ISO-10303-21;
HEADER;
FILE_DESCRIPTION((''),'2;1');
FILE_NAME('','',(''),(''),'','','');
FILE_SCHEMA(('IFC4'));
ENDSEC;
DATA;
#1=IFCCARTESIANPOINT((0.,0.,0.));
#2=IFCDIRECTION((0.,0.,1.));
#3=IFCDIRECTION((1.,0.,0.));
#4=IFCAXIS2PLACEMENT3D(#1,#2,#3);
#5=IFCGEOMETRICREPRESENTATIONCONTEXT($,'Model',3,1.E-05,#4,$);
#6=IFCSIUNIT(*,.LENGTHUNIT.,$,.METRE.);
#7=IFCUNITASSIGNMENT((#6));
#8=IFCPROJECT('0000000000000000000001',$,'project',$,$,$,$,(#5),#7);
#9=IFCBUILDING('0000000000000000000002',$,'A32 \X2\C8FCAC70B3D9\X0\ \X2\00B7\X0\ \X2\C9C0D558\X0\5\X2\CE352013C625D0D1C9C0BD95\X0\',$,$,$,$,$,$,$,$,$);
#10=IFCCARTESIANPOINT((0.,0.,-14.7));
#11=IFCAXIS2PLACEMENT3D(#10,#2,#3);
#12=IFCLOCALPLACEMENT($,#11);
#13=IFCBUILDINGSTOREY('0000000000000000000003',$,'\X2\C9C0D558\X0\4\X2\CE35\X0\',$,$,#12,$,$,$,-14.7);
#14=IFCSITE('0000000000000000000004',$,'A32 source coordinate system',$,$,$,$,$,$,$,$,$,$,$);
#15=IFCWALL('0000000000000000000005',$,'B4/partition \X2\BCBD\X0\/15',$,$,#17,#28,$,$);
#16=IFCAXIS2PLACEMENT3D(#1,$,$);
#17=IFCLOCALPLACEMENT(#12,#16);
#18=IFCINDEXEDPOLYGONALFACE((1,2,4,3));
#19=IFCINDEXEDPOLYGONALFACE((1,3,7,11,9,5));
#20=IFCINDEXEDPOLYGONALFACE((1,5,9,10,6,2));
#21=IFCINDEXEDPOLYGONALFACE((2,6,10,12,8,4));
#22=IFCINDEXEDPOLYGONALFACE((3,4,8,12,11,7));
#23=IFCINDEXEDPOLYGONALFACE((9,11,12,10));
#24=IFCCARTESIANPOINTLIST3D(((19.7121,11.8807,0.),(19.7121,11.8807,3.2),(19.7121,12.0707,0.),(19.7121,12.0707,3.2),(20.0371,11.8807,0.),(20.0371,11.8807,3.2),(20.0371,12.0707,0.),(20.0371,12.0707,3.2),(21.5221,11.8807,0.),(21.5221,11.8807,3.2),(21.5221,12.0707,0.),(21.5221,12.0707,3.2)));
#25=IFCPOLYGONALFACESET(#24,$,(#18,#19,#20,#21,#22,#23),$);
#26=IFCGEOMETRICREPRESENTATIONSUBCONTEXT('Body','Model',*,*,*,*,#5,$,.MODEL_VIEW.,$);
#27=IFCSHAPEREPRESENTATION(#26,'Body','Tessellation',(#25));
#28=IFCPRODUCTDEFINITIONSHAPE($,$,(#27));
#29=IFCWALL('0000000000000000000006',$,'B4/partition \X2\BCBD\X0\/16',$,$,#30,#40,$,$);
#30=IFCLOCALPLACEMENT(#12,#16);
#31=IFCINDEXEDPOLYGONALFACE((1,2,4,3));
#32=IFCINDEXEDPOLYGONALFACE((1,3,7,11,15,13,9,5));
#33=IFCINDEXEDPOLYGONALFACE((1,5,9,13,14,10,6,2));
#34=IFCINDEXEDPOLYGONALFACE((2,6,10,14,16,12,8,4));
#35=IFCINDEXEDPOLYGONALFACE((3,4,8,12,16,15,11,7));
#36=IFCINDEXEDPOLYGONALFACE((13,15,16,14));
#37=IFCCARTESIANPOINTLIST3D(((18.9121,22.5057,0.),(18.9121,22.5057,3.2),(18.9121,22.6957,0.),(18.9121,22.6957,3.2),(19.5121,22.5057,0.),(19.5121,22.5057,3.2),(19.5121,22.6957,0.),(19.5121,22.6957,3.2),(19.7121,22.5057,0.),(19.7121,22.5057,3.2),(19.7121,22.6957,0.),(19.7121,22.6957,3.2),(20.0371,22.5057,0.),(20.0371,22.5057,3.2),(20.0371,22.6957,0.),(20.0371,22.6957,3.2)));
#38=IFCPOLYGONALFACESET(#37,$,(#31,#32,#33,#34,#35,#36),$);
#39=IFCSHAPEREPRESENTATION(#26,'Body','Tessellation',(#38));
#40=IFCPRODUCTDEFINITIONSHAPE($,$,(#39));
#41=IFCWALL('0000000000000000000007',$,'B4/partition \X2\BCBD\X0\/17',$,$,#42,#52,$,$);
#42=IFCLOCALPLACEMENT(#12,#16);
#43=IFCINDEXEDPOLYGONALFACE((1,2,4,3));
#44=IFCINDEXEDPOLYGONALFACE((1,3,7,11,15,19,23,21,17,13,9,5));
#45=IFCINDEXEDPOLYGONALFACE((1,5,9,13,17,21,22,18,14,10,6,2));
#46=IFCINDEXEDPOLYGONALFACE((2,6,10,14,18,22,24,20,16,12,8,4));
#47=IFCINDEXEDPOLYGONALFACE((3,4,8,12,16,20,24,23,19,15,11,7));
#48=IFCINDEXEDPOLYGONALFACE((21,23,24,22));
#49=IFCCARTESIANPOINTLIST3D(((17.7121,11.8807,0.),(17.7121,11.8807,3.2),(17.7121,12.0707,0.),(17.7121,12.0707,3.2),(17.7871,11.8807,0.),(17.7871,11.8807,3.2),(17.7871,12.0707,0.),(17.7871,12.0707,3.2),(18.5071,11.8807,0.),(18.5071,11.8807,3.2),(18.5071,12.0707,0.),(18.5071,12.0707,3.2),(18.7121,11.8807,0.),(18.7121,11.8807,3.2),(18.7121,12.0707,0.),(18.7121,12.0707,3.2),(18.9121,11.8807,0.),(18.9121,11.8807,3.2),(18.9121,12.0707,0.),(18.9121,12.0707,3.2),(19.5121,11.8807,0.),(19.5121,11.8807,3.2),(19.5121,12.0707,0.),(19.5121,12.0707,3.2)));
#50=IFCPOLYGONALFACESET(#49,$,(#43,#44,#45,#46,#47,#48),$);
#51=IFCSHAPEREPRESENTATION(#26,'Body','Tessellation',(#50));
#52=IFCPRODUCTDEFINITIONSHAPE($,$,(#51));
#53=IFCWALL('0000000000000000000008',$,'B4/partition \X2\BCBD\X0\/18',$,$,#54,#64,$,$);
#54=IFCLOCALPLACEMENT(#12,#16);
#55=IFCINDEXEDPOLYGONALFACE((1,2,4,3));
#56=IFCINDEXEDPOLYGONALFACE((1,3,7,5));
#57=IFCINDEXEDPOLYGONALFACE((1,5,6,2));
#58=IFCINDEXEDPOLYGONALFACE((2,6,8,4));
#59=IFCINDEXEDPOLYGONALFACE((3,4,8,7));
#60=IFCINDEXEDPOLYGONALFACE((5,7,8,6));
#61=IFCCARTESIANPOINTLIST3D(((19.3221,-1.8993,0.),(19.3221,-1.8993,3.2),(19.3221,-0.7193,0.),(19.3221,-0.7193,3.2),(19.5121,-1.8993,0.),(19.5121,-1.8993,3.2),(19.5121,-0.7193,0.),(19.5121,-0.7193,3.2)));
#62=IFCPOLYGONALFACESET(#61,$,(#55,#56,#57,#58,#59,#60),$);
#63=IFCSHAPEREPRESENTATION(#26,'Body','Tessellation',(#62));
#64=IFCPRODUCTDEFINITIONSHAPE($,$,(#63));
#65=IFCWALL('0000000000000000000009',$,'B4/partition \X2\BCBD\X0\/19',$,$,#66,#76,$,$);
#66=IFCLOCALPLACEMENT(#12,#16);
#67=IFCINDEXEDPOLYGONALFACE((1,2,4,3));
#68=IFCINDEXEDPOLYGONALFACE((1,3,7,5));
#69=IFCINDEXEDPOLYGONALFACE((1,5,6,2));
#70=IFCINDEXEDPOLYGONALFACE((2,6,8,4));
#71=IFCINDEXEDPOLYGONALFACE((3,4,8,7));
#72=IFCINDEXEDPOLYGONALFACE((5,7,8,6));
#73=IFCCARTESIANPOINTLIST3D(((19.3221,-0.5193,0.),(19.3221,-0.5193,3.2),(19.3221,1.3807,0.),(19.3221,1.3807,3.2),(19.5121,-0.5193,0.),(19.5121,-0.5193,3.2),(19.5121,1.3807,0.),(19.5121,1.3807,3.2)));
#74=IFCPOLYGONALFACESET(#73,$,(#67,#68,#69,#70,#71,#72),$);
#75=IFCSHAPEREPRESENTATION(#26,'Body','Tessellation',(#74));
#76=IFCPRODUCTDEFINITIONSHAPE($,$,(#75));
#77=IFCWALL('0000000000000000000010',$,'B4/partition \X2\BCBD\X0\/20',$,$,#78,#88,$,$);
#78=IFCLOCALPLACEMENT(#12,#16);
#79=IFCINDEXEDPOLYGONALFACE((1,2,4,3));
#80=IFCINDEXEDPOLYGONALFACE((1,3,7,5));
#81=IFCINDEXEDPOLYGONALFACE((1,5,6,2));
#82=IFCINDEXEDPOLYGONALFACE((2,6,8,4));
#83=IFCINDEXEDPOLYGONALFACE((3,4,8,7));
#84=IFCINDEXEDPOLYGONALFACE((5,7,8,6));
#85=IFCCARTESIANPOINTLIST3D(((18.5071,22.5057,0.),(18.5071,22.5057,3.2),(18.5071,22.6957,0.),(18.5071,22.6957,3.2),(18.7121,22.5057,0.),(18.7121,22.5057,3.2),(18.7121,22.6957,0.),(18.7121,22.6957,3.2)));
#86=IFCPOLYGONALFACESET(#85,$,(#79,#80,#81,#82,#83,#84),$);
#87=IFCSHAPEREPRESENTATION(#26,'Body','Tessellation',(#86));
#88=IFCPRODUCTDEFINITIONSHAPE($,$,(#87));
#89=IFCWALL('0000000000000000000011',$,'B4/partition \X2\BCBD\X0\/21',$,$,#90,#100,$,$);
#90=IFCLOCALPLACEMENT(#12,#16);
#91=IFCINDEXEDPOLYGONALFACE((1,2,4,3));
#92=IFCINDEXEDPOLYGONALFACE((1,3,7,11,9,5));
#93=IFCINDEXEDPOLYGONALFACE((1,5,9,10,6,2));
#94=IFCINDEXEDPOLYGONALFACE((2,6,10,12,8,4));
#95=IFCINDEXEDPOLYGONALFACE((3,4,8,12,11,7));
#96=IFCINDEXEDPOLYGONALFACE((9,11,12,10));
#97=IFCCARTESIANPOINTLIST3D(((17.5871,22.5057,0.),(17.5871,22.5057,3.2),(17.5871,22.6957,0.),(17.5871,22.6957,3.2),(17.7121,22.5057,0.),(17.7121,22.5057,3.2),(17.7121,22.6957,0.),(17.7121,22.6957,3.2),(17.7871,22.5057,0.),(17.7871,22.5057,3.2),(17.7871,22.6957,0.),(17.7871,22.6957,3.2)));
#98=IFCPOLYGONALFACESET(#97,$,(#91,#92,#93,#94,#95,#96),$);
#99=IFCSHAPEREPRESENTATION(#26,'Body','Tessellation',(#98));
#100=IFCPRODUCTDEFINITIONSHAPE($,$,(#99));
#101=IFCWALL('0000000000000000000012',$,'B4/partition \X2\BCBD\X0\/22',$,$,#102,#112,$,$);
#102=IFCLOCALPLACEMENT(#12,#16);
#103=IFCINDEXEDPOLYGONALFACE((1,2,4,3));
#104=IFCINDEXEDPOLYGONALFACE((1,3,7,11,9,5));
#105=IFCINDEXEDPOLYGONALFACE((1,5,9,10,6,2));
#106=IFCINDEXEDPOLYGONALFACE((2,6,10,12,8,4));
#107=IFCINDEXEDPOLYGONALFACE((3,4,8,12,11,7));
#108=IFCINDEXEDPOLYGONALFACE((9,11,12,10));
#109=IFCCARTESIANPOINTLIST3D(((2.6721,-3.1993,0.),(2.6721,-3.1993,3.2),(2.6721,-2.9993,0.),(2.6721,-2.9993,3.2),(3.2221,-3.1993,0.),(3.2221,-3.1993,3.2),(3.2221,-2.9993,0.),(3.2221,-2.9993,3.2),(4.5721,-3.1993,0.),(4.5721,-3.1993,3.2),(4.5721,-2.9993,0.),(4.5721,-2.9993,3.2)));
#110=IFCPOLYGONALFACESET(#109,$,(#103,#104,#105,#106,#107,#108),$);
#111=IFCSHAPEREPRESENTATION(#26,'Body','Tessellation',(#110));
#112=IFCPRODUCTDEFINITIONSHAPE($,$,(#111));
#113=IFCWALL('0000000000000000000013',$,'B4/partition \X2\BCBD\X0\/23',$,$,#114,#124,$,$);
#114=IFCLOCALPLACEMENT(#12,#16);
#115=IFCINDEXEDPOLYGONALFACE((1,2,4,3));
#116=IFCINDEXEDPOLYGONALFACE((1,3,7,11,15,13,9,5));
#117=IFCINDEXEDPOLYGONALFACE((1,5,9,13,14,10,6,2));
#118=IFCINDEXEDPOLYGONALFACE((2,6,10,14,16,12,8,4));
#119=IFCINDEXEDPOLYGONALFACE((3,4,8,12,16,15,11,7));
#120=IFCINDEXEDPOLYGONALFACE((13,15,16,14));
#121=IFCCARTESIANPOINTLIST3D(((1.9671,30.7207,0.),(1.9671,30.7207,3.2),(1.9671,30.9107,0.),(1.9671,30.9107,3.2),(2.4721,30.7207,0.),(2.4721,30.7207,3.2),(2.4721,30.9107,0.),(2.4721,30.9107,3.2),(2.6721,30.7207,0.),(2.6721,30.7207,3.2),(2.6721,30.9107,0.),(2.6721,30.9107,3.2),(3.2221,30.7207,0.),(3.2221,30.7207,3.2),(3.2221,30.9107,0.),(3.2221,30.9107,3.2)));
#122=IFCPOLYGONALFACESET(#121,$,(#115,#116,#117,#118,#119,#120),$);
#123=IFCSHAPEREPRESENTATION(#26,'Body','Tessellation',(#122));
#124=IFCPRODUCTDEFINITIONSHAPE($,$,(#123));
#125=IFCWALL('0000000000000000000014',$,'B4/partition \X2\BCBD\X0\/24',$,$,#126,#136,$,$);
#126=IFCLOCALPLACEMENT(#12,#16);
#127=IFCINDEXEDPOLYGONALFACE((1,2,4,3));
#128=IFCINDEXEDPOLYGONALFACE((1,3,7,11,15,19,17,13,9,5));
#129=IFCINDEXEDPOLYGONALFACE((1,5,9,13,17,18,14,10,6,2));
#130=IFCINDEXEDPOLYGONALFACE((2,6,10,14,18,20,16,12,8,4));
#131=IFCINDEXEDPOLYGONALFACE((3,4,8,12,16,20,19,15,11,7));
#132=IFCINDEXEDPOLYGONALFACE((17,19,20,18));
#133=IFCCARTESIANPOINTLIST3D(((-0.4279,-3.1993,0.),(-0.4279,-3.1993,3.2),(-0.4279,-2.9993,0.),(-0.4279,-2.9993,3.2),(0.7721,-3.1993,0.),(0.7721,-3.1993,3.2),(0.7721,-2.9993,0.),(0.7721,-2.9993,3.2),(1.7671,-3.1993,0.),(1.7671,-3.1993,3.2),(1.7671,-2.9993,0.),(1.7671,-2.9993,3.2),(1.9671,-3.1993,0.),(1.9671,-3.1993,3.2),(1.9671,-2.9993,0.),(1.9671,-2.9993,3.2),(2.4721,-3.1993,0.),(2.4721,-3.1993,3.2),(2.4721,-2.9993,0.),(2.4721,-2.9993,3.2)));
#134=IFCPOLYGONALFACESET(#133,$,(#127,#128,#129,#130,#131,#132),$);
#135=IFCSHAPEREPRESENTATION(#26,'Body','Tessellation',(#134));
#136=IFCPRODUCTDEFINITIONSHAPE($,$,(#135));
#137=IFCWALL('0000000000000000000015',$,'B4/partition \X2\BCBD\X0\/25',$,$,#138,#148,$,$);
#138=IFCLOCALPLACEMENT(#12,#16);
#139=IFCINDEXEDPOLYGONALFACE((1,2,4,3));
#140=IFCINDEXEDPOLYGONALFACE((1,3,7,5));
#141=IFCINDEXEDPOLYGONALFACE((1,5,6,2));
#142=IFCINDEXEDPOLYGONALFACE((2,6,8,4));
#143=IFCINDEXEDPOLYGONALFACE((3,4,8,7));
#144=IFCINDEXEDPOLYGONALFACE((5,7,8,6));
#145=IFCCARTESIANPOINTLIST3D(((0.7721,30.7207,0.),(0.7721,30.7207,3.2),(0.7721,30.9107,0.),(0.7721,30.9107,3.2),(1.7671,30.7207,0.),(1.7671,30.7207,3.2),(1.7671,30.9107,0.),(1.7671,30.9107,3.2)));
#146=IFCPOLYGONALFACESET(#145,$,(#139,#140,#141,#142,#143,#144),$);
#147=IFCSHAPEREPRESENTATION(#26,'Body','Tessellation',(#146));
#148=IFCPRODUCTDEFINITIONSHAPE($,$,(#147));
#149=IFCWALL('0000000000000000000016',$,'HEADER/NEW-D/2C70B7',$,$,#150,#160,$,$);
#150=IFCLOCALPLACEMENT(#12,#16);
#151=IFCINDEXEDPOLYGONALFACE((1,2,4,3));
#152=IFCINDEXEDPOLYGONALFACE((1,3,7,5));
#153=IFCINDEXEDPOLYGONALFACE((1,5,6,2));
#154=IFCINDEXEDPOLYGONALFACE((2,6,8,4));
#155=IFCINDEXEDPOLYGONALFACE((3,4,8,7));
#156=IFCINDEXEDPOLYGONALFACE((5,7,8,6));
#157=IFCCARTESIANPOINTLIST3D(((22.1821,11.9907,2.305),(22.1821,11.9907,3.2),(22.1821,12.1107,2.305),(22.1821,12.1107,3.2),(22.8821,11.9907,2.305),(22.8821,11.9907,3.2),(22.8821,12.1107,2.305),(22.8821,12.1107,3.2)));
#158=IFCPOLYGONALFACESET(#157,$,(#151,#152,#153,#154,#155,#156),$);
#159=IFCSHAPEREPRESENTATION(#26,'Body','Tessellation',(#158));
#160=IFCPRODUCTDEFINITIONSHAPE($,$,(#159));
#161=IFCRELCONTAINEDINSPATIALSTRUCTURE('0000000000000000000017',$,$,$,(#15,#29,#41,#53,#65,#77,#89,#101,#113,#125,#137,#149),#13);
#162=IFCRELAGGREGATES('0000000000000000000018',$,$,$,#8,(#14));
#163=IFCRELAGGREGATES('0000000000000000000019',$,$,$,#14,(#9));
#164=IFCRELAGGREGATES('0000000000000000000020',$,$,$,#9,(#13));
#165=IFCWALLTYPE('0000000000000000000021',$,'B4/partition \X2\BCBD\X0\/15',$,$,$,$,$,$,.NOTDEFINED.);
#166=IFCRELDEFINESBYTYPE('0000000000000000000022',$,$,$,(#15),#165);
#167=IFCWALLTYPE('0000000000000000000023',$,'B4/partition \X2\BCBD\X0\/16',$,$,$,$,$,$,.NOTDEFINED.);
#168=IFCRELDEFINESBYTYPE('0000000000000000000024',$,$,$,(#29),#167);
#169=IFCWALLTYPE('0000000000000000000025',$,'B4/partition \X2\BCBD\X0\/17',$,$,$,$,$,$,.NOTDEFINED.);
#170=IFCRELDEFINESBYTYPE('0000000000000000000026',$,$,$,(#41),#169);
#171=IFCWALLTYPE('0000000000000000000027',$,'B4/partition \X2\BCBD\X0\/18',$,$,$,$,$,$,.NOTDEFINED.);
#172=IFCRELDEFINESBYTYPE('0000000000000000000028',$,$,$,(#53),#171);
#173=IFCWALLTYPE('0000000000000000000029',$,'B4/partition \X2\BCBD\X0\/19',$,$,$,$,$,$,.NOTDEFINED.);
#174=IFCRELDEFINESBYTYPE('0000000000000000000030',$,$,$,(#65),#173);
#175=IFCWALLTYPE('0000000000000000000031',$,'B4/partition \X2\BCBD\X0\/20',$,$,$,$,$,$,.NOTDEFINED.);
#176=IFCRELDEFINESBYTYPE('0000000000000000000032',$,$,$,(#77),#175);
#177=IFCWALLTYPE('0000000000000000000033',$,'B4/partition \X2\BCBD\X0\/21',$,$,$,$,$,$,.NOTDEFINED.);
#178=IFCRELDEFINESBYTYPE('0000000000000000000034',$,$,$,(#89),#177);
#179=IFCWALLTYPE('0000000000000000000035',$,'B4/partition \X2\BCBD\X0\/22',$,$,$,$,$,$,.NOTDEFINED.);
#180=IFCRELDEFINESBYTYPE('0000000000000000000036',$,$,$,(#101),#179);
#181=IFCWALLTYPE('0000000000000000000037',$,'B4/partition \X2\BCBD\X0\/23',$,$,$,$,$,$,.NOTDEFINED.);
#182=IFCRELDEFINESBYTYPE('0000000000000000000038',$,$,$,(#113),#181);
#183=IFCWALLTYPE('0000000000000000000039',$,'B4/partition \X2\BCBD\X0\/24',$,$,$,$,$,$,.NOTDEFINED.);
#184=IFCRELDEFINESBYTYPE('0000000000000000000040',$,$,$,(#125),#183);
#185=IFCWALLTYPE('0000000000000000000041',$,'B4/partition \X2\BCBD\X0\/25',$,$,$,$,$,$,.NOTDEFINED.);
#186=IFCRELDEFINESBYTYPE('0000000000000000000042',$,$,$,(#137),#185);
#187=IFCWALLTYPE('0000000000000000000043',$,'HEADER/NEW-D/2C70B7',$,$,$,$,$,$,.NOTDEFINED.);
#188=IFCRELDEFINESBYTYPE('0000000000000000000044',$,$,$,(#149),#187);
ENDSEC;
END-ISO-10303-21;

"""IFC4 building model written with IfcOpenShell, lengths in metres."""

from ifc_helpers import new_model, si_unit, frame, origin, origin_with_axes, place, context, subcontext, project, spatial, polyline, outline, extrude, source, transform, mapped, type_object, type_shapes, element, save


model = new_model("IFC4")

# Units and contexts
model_context = context("Model", 3, precision=1e-05, world=origin_with_axes())
body_context = subcontext(model_context, "Body", "Model", "MODEL_VIEW")
ifc_project = project(units=[si_unit("LENGTHUNIT", "METRE")], contexts=[model_context])

# Site, building, storey
site = spatial("IfcSite", under=ifc_project, Name="A32 source coordinate system")
building = spatial("IfcBuilding", under=site, Name="A32 주거동 · 지하5층–옥탑지붕")
storey_placement = place(None, frame((0.0, 0.0, -14.7), z_axis=(0.0, 0.0, 1.0), x_axis=(1.0, 0.0, 0.0)))
storey = spatial("IfcBuildingStorey", under=building, at=storey_placement, Name="지하4층", Elevation=-14.7)

# Walls
wall_type_1 = type_object("IfcWallType", Name="B4/partition 벽/15", PredefinedType="NOTDEFINED")
shared_shape_1 = source(origin(), body_context, "Body", "SweptSolid", [
    extrude(outline(polyline([(19.7121, 11.8807), (19.7121, 12.0707), (20.0371, 12.0707), (21.5221, 12.0707), (21.5221, 11.8807), (20.0371, 11.8807), (19.7121, 11.8807)])), origin(), (0.0, 0.0, 1.0), 3.2),
])
type_shapes(wall_type_1, [shared_shape_1])
wall_1_placement = place(storey_placement, origin_with_axes())
element("IfcWall", 1, at=wall_1_placement, inside=storey, type_object=wall_type_1, Name="B4/partition 벽/15", context=body_context, shape_type="MappedRepresentation", body=[
    mapped(shared_shape_1, transform((0.0, 0.0, 0.0), scale=1.0)),
])
wall_type_2 = type_object("IfcWallType", Name="B4/partition 벽/16", PredefinedType="NOTDEFINED")
shared_shape_2 = source(origin(), body_context, "Body", "SweptSolid", [
    extrude(outline(polyline([(20.0371, 22.5057), (19.7121, 22.5057), (19.5121, 22.5057), (18.9121, 22.5057), (18.9121, 22.6957), (19.5121, 22.6957), (19.7121, 22.6957), (20.0371, 22.6957), (20.0371, 22.5057)])), origin(), (0.0, 0.0, 1.0), 3.2),
])
type_shapes(wall_type_2, [shared_shape_2])
wall_2_placement = place(storey_placement, origin_with_axes())
element("IfcWall", 2, at=wall_2_placement, inside=storey, type_object=wall_type_2, Name="B4/partition 벽/16", context=body_context, shape_type="MappedRepresentation", body=[
    mapped(shared_shape_2, transform((0.0, 0.0, 0.0), scale=1.0)),
])
wall_type_3 = type_object("IfcWallType", Name="B4/partition 벽/17", PredefinedType="NOTDEFINED")
shared_shape_3 = source(origin(), body_context, "Body", "SweptSolid", [
    extrude(outline(polyline([(18.9121, 12.0707), (19.5121, 12.0707), (19.5121, 11.8807), (18.9121, 11.8807), (18.7121, 11.8807), (18.5071, 11.8807), (17.7871, 11.8807), (17.7121, 11.8807), (17.7121, 12.0707), (17.7871, 12.0707), (18.5071, 12.0707), (18.7121, 12.0707), (18.9121, 12.0707)])), origin(), (0.0, 0.0, 1.0), 3.2),
])
type_shapes(wall_type_3, [shared_shape_3])
wall_3_placement = place(storey_placement, origin_with_axes())
element("IfcWall", 3, at=wall_3_placement, inside=storey, type_object=wall_type_3, Name="B4/partition 벽/17", context=body_context, shape_type="MappedRepresentation", body=[
    mapped(shared_shape_3, transform((0.0, 0.0, 0.0), scale=1.0)),
])
wall_type_4 = type_object("IfcWallType", Name="B4/partition 벽/18", PredefinedType="NOTDEFINED")
shared_shape_4 = source(origin(), body_context, "Body", "SweptSolid", [
    extrude(outline(polyline([(19.5121, -0.7193), (19.5121, -1.8993), (19.3221, -1.8993), (19.3221, -0.7193), (19.5121, -0.7193)])), origin(), (0.0, 0.0, 1.0), 3.2),
])
type_shapes(wall_type_4, [shared_shape_4])
wall_4_placement = place(storey_placement, origin_with_axes())
element("IfcWall", 4, at=wall_4_placement, inside=storey, type_object=wall_type_4, Name="B4/partition 벽/18", context=body_context, shape_type="MappedRepresentation", body=[
    mapped(shared_shape_4, transform((0.0, 0.0, 0.0), scale=1.0)),
])
wall_type_5 = type_object("IfcWallType", Name="B4/partition 벽/19", PredefinedType="NOTDEFINED")
shared_shape_5 = source(origin(), body_context, "Body", "SweptSolid", [
    extrude(outline(polyline([(19.3221, 1.3807), (19.5121, 1.3807), (19.5121, -0.5193), (19.3221, -0.5193), (19.3221, 1.3807)])), origin(), (0.0, 0.0, 1.0), 3.2),
])
type_shapes(wall_type_5, [shared_shape_5])
wall_5_placement = place(storey_placement, origin_with_axes())
element("IfcWall", 5, at=wall_5_placement, inside=storey, type_object=wall_type_5, Name="B4/partition 벽/19", context=body_context, shape_type="MappedRepresentation", body=[
    mapped(shared_shape_5, transform((0.0, 0.0, 0.0), scale=1.0)),
])
wall_type_6 = type_object("IfcWallType", Name="B4/partition 벽/20", PredefinedType="NOTDEFINED")
shared_shape_6 = source(origin(), body_context, "Body", "SweptSolid", [
    extrude(outline(polyline([(18.5071, 22.6957), (18.7121, 22.6957), (18.7121, 22.5057), (18.5071, 22.5057), (18.5071, 22.6957)])), origin(), (0.0, 0.0, 1.0), 3.2),
])
type_shapes(wall_type_6, [shared_shape_6])
wall_6_placement = place(storey_placement, origin_with_axes())
element("IfcWall", 6, at=wall_6_placement, inside=storey, type_object=wall_type_6, Name="B4/partition 벽/20", context=body_context, shape_type="MappedRepresentation", body=[
    mapped(shared_shape_6, transform((0.0, 0.0, 0.0), scale=1.0)),
])
wall_type_7 = type_object("IfcWallType", Name="B4/partition 벽/21", PredefinedType="NOTDEFINED")
shared_shape_7 = source(origin(), body_context, "Body", "SweptSolid", [
    extrude(outline(polyline([(17.5871, 22.5057), (17.5871, 22.6957), (17.7121, 22.6957), (17.7871, 22.6957), (17.7871, 22.5057), (17.7121, 22.5057), (17.5871, 22.5057)])), origin(), (0.0, 0.0, 1.0), 3.2),
])
type_shapes(wall_type_7, [shared_shape_7])
wall_7_placement = place(storey_placement, origin_with_axes())
element("IfcWall", 7, at=wall_7_placement, inside=storey, type_object=wall_type_7, Name="B4/partition 벽/21", context=body_context, shape_type="MappedRepresentation", body=[
    mapped(shared_shape_7, transform((0.0, 0.0, 0.0), scale=1.0)),
])
wall_type_8 = type_object("IfcWallType", Name="B4/partition 벽/22", PredefinedType="NOTDEFINED")
shared_shape_8 = source(origin(), body_context, "Body", "SweptSolid", [
    extrude(outline(polyline([(2.6721, -3.1993), (2.6721, -2.9993), (3.2221, -2.9993), (4.5721, -2.9993), (4.5721, -3.1993), (3.2221, -3.1993), (2.6721, -3.1993)])), origin(), (0.0, 0.0, 1.0), 3.2),
])
type_shapes(wall_type_8, [shared_shape_8])
wall_8_placement = place(storey_placement, origin_with_axes())
element("IfcWall", 8, at=wall_8_placement, inside=storey, type_object=wall_type_8, Name="B4/partition 벽/22", context=body_context, shape_type="MappedRepresentation", body=[
    mapped(shared_shape_8, transform((0.0, 0.0, 0.0), scale=1.0)),
])
wall_type_9 = type_object("IfcWallType", Name="B4/partition 벽/23", PredefinedType="NOTDEFINED")
shared_shape_9 = source(origin(), body_context, "Body", "SweptSolid", [
    extrude(outline(polyline([(2.6721, 30.7207), (2.4721, 30.7207), (1.9671, 30.7207), (1.9671, 30.9107), (2.4721, 30.9107), (2.6721, 30.9107), (3.2221, 30.9107), (3.2221, 30.7207), (2.6721, 30.7207)])), origin(), (0.0, 0.0, 1.0), 3.2),
])
type_shapes(wall_type_9, [shared_shape_9])
wall_9_placement = place(storey_placement, origin_with_axes())
element("IfcWall", 9, at=wall_9_placement, inside=storey, type_object=wall_type_9, Name="B4/partition 벽/23", context=body_context, shape_type="MappedRepresentation", body=[
    mapped(shared_shape_9, transform((0.0, 0.0, 0.0), scale=1.0)),
])
wall_type_10 = type_object("IfcWallType", Name="B4/partition 벽/24", PredefinedType="NOTDEFINED")
shared_shape_10 = source(origin(), body_context, "Body", "SweptSolid", [
    extrude(outline(polyline([(2.4721, -2.9993), (2.4721, -3.1993), (1.9671, -3.1993), (1.7671, -3.1993), (0.7721, -3.1993), (-0.4279, -3.1993), (-0.4279, -2.9993), (0.7721, -2.9993), (1.7671, -2.9993), (1.9671, -2.9993), (2.4721, -2.9993)])), origin(), (0.0, 0.0, 1.0), 3.2),
])
type_shapes(wall_type_10, [shared_shape_10])
wall_10_placement = place(storey_placement, origin_with_axes())
element("IfcWall", 10, at=wall_10_placement, inside=storey, type_object=wall_type_10, Name="B4/partition 벽/24", context=body_context, shape_type="MappedRepresentation", body=[
    mapped(shared_shape_10, transform((0.0, 0.0, 0.0), scale=1.0)),
])
wall_type_11 = type_object("IfcWallType", Name="B4/partition 벽/25", PredefinedType="NOTDEFINED")
shared_shape_11 = source(origin(), body_context, "Body", "SweptSolid", [
    extrude(outline(polyline([(1.7671, 30.9107), (1.7671, 30.7207), (0.7721, 30.7207), (0.7721, 30.9107), (1.7671, 30.9107)])), origin(), (0.0, 0.0, 1.0), 3.2),
])
type_shapes(wall_type_11, [shared_shape_11])
wall_11_placement = place(storey_placement, origin_with_axes())
element("IfcWall", 11, at=wall_11_placement, inside=storey, type_object=wall_type_11, Name="B4/partition 벽/25", context=body_context, shape_type="MappedRepresentation", body=[
    mapped(shared_shape_11, transform((0.0, 0.0, 0.0), scale=1.0)),
])
wall_type_12 = type_object("IfcWallType", Name="HEADER/NEW-D/2C70B7", PredefinedType="NOTDEFINED")
shared_shape_12 = source(origin(), body_context, "Body", "SweptSolid", [
    extrude(outline(polyline([(22.1821, 11.9907), (22.1821, 12.1107), (22.8821, 12.1107), (22.8821, 11.9907), (22.1821, 11.9907)])), frame((0.0, 0.0, 2.305)), (0.0, 0.0, 1.0), 0.895),
])
type_shapes(wall_type_12, [shared_shape_12])
wall_12_placement = place(storey_placement, origin_with_axes())
element("IfcWall", 12, at=wall_12_placement, inside=storey, type_object=wall_type_12, Name="HEADER/NEW-D/2C70B7", context=body_context, shape_type="MappedRepresentation", body=[
    mapped(shared_shape_12, transform((0.0, 0.0, 0.0), scale=1.0)),
])

save(model, "model.ifc")
